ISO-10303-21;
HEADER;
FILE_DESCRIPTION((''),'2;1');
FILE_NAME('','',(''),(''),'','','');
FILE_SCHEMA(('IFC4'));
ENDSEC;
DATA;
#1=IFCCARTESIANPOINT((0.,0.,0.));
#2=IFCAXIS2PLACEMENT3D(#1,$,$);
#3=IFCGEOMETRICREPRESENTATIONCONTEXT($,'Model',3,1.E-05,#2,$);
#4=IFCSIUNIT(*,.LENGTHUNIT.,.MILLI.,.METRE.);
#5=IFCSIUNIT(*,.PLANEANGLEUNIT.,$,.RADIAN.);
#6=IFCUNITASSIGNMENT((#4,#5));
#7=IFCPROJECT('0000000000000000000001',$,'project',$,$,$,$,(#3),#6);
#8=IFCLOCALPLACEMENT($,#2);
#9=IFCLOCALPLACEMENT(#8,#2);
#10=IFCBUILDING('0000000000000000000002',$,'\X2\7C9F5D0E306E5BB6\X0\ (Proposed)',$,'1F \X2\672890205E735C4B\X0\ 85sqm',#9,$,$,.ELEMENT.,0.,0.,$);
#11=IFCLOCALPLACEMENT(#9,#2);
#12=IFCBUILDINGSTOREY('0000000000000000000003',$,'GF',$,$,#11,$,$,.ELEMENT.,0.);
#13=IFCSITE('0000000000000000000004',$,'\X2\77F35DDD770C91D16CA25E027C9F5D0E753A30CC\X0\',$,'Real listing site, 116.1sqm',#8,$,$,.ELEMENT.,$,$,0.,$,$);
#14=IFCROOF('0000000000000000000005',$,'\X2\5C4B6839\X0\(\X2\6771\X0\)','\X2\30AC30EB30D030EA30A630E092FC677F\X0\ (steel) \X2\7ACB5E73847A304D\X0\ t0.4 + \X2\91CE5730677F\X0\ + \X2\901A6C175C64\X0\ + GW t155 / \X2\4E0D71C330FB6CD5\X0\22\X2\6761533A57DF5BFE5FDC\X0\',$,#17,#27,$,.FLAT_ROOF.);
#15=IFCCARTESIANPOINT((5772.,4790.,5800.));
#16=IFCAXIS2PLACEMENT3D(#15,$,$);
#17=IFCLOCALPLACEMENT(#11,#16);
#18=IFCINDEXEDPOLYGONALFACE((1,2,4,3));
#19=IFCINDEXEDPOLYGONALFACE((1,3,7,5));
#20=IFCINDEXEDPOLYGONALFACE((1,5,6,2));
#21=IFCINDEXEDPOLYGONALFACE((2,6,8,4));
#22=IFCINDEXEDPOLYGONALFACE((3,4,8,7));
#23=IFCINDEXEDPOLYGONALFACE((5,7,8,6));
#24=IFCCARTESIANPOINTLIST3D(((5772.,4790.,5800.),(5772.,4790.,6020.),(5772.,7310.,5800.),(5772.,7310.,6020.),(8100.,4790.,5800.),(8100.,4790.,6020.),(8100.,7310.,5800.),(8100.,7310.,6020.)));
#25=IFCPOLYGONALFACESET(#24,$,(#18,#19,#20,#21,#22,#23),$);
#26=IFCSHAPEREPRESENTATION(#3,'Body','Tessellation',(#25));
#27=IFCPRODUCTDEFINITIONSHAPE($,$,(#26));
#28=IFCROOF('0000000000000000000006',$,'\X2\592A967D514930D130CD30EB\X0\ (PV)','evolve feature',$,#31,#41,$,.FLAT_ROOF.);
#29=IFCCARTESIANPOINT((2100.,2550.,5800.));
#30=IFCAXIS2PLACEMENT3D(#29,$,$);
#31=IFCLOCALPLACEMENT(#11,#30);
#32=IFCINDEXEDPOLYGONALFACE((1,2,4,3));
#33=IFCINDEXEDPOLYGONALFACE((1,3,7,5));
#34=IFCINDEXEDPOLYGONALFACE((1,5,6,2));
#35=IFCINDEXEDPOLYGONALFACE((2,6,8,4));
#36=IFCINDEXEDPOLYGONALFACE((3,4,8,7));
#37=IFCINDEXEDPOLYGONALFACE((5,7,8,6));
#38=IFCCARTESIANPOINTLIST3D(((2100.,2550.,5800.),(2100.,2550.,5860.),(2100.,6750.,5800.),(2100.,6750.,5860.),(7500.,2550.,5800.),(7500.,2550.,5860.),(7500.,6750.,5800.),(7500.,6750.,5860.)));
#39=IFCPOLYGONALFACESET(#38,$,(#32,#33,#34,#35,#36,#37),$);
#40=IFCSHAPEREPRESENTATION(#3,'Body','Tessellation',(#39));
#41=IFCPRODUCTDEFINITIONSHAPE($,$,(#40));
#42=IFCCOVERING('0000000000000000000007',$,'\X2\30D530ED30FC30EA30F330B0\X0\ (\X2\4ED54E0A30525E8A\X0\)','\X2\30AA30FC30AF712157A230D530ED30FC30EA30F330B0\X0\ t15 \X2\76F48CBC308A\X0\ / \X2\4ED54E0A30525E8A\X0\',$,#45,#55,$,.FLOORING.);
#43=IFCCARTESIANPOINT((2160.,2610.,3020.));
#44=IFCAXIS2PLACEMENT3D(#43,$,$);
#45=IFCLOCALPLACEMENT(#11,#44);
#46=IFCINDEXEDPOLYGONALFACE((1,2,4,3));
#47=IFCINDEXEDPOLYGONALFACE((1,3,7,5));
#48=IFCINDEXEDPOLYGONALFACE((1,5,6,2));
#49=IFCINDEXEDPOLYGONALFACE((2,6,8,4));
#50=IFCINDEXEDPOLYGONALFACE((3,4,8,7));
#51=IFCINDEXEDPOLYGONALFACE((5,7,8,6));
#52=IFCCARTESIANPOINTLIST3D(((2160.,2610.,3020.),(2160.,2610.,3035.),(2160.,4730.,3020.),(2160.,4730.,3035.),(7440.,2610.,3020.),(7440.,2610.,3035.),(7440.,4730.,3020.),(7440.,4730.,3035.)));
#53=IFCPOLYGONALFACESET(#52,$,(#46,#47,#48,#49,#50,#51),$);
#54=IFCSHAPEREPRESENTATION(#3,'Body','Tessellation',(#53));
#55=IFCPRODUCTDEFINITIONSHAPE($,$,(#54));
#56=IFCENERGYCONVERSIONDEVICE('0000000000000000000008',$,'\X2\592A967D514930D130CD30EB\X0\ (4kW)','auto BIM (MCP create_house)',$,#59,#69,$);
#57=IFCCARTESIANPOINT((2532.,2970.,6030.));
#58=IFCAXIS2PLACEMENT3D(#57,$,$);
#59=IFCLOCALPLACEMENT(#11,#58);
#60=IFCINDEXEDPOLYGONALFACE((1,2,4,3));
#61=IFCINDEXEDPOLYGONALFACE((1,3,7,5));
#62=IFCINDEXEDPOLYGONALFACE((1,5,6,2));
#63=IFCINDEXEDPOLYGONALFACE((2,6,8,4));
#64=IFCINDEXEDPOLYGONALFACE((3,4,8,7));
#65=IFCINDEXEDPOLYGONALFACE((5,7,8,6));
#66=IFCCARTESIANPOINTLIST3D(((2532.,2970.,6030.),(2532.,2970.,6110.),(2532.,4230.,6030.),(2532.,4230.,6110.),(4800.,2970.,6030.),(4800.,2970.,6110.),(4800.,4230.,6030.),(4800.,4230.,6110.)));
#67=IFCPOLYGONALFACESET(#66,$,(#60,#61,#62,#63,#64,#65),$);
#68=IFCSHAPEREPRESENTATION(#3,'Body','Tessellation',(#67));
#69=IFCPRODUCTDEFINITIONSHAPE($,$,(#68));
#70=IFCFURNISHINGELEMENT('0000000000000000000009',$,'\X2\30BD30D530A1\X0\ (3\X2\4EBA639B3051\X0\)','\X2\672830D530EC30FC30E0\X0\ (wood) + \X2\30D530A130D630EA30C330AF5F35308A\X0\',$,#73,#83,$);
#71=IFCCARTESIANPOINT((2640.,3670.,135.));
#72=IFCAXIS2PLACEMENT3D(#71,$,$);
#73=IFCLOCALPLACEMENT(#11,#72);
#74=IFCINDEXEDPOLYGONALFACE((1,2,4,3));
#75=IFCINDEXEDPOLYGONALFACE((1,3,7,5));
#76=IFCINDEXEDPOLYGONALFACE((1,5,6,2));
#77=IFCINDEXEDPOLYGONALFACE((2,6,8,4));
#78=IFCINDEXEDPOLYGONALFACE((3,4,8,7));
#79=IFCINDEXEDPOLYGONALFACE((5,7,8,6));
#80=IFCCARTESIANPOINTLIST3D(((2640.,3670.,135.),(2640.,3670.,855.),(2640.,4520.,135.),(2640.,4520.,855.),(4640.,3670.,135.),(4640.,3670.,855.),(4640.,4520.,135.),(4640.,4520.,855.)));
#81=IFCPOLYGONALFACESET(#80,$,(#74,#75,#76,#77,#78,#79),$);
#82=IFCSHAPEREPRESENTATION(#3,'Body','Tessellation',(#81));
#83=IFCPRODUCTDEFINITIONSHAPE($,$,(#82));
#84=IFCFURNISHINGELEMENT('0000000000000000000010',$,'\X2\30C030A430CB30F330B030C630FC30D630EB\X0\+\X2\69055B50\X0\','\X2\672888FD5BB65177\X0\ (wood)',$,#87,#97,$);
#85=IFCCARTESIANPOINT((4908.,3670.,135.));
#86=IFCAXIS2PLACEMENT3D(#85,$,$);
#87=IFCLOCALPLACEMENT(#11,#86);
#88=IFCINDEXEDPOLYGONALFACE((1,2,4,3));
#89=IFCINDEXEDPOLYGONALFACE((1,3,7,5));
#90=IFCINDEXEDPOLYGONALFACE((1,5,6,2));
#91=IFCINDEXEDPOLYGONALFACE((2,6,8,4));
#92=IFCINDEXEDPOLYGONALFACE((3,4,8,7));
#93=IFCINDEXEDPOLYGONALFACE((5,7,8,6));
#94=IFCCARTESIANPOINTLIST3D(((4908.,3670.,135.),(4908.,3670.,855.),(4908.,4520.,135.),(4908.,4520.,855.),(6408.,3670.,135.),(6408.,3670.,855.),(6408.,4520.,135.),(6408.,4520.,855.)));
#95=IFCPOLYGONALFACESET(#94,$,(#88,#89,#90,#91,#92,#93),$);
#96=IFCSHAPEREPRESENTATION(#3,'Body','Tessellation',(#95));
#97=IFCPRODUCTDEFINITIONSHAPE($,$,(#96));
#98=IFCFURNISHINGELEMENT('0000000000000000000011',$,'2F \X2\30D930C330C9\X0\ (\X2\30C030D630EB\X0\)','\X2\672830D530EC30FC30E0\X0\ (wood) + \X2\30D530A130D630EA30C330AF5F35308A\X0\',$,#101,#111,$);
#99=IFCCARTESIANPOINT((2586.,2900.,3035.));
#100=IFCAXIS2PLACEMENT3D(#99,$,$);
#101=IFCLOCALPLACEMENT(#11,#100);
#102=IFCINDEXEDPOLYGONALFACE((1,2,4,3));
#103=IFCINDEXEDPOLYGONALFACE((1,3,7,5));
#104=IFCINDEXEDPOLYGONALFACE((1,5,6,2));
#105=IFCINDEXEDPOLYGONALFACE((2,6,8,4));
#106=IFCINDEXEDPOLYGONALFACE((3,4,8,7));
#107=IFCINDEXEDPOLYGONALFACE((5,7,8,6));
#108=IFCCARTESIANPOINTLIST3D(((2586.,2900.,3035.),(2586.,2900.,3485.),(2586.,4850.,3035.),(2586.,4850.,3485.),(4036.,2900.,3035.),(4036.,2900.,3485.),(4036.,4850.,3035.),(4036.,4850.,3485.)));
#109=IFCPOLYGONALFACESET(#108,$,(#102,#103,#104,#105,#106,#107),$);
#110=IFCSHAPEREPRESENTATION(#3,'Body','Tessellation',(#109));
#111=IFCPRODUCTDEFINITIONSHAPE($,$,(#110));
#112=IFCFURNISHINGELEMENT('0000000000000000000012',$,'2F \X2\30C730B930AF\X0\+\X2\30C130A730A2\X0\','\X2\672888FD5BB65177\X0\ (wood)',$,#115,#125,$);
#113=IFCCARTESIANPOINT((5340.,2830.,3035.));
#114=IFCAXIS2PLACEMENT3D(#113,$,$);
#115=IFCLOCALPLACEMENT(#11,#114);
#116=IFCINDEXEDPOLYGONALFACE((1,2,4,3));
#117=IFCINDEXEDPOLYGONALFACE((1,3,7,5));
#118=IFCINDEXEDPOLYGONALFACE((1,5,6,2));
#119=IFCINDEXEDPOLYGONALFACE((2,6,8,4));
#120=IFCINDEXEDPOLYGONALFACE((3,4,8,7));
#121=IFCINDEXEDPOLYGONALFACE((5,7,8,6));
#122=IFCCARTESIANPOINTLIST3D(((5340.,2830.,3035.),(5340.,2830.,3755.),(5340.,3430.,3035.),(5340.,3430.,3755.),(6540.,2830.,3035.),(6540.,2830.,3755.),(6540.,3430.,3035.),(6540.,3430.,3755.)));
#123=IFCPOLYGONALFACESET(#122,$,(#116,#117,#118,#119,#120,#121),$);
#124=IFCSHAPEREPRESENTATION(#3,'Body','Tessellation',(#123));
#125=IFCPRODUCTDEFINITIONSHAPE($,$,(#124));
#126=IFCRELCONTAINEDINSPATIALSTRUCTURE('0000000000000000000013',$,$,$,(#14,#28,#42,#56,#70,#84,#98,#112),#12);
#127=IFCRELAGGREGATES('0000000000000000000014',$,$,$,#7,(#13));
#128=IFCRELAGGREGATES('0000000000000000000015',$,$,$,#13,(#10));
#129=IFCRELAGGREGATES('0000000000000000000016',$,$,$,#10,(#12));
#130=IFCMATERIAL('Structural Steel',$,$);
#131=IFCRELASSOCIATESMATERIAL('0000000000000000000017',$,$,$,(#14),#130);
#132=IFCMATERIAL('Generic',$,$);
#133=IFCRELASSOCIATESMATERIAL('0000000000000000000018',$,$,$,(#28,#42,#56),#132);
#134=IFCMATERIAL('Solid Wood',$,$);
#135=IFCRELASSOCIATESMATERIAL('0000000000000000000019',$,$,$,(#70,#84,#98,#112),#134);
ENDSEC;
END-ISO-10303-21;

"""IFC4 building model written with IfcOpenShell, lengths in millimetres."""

from ifc_helpers import new_model, si_unit, frame, frame_2d, origin, place, context, project, spatial, rectangle, extrude, material, element, save


model = new_model("IFC4")

# Units and contexts
model_context = context("Model", 3, precision=1e-05, world=origin())
ifc_project = project(units=[si_unit("LENGTHUNIT", "METRE", prefix="MILLI"), si_unit("PLANEANGLEUNIT", "RADIAN")], contexts=[model_context])

# Site, building, storey
site_placement = place(None, origin())
site = spatial("IfcSite", under=ifc_project, at=site_placement, Name="石川県金沢市粟崎町ヌ", ObjectType="Real listing site, 116.1sqm", CompositionType="ELEMENT", RefElevation=0.0)
building_placement = place(site_placement, origin())
building = spatial("IfcBuilding", under=site, at=building_placement, Name="粟崎の家 (Proposed)", ObjectType="1F 木造平屋 85sqm", CompositionType="ELEMENT", ElevationOfRefHeight=0.0, ElevationOfTerrain=0.0)
storey_placement = place(building_placement, origin())
storey = spatial("IfcBuildingStorey", under=building, at=storey_placement, Name="GF", CompositionType="ELEMENT", Elevation=0.0)

# Shared definitions
ifc_material_1 = material(Name="Solid Wood")

# Roofs
ifc_material_2 = material(Name="Structural Steel")
roof_1_placement = place(storey_placement, frame((5772.0, 4790.0, 5800.0)))
element("IfcRoof", 1, at=roof_1_placement, inside=storey, material=ifc_material_2, Name="屋根(東)", Description="ガルバリウム鋼板 (steel) 立平葺き t0.4 + 野地板 + 通気層 + GW t155 / 不燃・法22条区域対応", PredefinedType="FLAT_ROOF", context=model_context, shape_type="SweptSolid", body=[
    extrude(rectangle(XDim=2328.0, YDim=2520.0, at=frame_2d((1164.0, 1260.0))), frame((5772.0, 4790.0, 5800.0)), (0.0, 0.0, 1.0), 220.0),
])
ifc_material_3 = material(Name="Generic")
roof_2_placement = place(storey_placement, frame((2100.0, 2550.0, 5800.0)))
element("IfcRoof", 2, at=roof_2_placement, inside=storey, material=ifc_material_3, Name="太陽光パネル (PV)", Description="evolve feature", PredefinedType="FLAT_ROOF", context=model_context, shape_type="SweptSolid", body=[
    extrude(rectangle(XDim=5400.0, YDim=4200.0, at=frame_2d((2700.0, 2100.0))), frame((2100.0, 2550.0, 5800.0)), (0.0, 0.0, 1.0), 60.0),
])

# Covering
covering_placement = place(storey_placement, frame((2160.0, 2610.0, 3020.0)))
element("IfcCovering", 3, at=covering_placement, inside=storey, material=ifc_material_3, Name="フローリング (仕上げ床)", Description="オーク無垢フローリング t15 直貼り / 仕上げ床", PredefinedType="FLOORING", context=model_context, shape_type="SweptSolid", body=[
    extrude(rectangle(XDim=5280.0, YDim=2120.0, at=frame_2d((2640.0, 1060.0))), frame((2160.0, 2610.0, 3020.0)), (0.0, 0.0, 1.0), 15.0),
])

# Energy conversion device
energy_conversion_device_placement = place(storey_placement, frame((2532.0, 2970.0, 6030.0)))
element("IfcEnergyConversionDevice", 4, at=energy_conversion_device_placement, inside=storey, material=ifc_material_3, Name="太陽光パネル (4kW)", Description="auto BIM (MCP create_house)", context=model_context, shape_type="SweptSolid", body=[
    extrude(rectangle(XDim=2268.0, YDim=1260.0, at=frame_2d((1134.0, 630.0))), frame((2532.0, 2970.0, 6030.0)), (0.0, 0.0, 1.0), 80.0),
])

# Furnishing elements
furnishing_1_placement = place(storey_placement, frame((2640.0, 3670.0, 135.0)))
element("IfcFurnishingElement", 5, at=furnishing_1_placement, inside=storey, material=ifc_material_1, Name="ソファ (3人掛け)", Description="木フレーム (wood) + ファブリック張り", context=model_context, shape_type="SweptSolid", body=[
    extrude(rectangle(XDim=2000.0, YDim=850.0, at=frame_2d((1000.0, 425.0))), frame((2640.0, 3670.0, 135.0)), (0.0, 0.0, 1.0), 720.0),
])
furnishing_2_placement = place(storey_placement, frame((4908.0, 3670.0, 135.0)))
element("IfcFurnishingElement", 6, at=furnishing_2_placement, inside=storey, material=ifc_material_1, Name="ダイニングテーブル+椅子", Description="木製家具 (wood)", context=model_context, shape_type="SweptSolid", body=[
    extrude(rectangle(XDim=1500.0, YDim=850.0, at=frame_2d((750.0, 425.0))), frame((4908.0, 3670.0, 135.0)), (0.0, 0.0, 1.0), 720.0),
])
furnishing_3_placement = place(storey_placement, frame((2586.0, 2900.0, 3035.0)))
element("IfcFurnishingElement", 7, at=furnishing_3_placement, inside=storey, material=ifc_material_1, Name="2F ベッド (ダブル)", Description="木フレーム (wood) + ファブリック張り", context=model_context, shape_type="SweptSolid", body=[
    extrude(rectangle(XDim=1450.0, YDim=1950.0, at=frame_2d((725.0, 975.0))), frame((2586.0, 2900.0, 3035.0)), (0.0, 0.0, 1.0), 450.0),
])
furnishing_4_placement = place(storey_placement, frame((5340.0, 2830.0, 3035.0)))
element("IfcFurnishingElement", 8, at=furnishing_4_placement, inside=storey, material=ifc_material_1, Name="2F デスク+チェア", Description="木製家具 (wood)", context=model_context, shape_type="SweptSolid", body=[
    extrude(rectangle(XDim=1200.0, YDim=600.0, at=frame_2d((600.0, 300.0))), frame((5340.0, 2830.0, 3035.0)), (0.0, 0.0, 1.0), 720.0),
])

save(model, "model.ifc")
